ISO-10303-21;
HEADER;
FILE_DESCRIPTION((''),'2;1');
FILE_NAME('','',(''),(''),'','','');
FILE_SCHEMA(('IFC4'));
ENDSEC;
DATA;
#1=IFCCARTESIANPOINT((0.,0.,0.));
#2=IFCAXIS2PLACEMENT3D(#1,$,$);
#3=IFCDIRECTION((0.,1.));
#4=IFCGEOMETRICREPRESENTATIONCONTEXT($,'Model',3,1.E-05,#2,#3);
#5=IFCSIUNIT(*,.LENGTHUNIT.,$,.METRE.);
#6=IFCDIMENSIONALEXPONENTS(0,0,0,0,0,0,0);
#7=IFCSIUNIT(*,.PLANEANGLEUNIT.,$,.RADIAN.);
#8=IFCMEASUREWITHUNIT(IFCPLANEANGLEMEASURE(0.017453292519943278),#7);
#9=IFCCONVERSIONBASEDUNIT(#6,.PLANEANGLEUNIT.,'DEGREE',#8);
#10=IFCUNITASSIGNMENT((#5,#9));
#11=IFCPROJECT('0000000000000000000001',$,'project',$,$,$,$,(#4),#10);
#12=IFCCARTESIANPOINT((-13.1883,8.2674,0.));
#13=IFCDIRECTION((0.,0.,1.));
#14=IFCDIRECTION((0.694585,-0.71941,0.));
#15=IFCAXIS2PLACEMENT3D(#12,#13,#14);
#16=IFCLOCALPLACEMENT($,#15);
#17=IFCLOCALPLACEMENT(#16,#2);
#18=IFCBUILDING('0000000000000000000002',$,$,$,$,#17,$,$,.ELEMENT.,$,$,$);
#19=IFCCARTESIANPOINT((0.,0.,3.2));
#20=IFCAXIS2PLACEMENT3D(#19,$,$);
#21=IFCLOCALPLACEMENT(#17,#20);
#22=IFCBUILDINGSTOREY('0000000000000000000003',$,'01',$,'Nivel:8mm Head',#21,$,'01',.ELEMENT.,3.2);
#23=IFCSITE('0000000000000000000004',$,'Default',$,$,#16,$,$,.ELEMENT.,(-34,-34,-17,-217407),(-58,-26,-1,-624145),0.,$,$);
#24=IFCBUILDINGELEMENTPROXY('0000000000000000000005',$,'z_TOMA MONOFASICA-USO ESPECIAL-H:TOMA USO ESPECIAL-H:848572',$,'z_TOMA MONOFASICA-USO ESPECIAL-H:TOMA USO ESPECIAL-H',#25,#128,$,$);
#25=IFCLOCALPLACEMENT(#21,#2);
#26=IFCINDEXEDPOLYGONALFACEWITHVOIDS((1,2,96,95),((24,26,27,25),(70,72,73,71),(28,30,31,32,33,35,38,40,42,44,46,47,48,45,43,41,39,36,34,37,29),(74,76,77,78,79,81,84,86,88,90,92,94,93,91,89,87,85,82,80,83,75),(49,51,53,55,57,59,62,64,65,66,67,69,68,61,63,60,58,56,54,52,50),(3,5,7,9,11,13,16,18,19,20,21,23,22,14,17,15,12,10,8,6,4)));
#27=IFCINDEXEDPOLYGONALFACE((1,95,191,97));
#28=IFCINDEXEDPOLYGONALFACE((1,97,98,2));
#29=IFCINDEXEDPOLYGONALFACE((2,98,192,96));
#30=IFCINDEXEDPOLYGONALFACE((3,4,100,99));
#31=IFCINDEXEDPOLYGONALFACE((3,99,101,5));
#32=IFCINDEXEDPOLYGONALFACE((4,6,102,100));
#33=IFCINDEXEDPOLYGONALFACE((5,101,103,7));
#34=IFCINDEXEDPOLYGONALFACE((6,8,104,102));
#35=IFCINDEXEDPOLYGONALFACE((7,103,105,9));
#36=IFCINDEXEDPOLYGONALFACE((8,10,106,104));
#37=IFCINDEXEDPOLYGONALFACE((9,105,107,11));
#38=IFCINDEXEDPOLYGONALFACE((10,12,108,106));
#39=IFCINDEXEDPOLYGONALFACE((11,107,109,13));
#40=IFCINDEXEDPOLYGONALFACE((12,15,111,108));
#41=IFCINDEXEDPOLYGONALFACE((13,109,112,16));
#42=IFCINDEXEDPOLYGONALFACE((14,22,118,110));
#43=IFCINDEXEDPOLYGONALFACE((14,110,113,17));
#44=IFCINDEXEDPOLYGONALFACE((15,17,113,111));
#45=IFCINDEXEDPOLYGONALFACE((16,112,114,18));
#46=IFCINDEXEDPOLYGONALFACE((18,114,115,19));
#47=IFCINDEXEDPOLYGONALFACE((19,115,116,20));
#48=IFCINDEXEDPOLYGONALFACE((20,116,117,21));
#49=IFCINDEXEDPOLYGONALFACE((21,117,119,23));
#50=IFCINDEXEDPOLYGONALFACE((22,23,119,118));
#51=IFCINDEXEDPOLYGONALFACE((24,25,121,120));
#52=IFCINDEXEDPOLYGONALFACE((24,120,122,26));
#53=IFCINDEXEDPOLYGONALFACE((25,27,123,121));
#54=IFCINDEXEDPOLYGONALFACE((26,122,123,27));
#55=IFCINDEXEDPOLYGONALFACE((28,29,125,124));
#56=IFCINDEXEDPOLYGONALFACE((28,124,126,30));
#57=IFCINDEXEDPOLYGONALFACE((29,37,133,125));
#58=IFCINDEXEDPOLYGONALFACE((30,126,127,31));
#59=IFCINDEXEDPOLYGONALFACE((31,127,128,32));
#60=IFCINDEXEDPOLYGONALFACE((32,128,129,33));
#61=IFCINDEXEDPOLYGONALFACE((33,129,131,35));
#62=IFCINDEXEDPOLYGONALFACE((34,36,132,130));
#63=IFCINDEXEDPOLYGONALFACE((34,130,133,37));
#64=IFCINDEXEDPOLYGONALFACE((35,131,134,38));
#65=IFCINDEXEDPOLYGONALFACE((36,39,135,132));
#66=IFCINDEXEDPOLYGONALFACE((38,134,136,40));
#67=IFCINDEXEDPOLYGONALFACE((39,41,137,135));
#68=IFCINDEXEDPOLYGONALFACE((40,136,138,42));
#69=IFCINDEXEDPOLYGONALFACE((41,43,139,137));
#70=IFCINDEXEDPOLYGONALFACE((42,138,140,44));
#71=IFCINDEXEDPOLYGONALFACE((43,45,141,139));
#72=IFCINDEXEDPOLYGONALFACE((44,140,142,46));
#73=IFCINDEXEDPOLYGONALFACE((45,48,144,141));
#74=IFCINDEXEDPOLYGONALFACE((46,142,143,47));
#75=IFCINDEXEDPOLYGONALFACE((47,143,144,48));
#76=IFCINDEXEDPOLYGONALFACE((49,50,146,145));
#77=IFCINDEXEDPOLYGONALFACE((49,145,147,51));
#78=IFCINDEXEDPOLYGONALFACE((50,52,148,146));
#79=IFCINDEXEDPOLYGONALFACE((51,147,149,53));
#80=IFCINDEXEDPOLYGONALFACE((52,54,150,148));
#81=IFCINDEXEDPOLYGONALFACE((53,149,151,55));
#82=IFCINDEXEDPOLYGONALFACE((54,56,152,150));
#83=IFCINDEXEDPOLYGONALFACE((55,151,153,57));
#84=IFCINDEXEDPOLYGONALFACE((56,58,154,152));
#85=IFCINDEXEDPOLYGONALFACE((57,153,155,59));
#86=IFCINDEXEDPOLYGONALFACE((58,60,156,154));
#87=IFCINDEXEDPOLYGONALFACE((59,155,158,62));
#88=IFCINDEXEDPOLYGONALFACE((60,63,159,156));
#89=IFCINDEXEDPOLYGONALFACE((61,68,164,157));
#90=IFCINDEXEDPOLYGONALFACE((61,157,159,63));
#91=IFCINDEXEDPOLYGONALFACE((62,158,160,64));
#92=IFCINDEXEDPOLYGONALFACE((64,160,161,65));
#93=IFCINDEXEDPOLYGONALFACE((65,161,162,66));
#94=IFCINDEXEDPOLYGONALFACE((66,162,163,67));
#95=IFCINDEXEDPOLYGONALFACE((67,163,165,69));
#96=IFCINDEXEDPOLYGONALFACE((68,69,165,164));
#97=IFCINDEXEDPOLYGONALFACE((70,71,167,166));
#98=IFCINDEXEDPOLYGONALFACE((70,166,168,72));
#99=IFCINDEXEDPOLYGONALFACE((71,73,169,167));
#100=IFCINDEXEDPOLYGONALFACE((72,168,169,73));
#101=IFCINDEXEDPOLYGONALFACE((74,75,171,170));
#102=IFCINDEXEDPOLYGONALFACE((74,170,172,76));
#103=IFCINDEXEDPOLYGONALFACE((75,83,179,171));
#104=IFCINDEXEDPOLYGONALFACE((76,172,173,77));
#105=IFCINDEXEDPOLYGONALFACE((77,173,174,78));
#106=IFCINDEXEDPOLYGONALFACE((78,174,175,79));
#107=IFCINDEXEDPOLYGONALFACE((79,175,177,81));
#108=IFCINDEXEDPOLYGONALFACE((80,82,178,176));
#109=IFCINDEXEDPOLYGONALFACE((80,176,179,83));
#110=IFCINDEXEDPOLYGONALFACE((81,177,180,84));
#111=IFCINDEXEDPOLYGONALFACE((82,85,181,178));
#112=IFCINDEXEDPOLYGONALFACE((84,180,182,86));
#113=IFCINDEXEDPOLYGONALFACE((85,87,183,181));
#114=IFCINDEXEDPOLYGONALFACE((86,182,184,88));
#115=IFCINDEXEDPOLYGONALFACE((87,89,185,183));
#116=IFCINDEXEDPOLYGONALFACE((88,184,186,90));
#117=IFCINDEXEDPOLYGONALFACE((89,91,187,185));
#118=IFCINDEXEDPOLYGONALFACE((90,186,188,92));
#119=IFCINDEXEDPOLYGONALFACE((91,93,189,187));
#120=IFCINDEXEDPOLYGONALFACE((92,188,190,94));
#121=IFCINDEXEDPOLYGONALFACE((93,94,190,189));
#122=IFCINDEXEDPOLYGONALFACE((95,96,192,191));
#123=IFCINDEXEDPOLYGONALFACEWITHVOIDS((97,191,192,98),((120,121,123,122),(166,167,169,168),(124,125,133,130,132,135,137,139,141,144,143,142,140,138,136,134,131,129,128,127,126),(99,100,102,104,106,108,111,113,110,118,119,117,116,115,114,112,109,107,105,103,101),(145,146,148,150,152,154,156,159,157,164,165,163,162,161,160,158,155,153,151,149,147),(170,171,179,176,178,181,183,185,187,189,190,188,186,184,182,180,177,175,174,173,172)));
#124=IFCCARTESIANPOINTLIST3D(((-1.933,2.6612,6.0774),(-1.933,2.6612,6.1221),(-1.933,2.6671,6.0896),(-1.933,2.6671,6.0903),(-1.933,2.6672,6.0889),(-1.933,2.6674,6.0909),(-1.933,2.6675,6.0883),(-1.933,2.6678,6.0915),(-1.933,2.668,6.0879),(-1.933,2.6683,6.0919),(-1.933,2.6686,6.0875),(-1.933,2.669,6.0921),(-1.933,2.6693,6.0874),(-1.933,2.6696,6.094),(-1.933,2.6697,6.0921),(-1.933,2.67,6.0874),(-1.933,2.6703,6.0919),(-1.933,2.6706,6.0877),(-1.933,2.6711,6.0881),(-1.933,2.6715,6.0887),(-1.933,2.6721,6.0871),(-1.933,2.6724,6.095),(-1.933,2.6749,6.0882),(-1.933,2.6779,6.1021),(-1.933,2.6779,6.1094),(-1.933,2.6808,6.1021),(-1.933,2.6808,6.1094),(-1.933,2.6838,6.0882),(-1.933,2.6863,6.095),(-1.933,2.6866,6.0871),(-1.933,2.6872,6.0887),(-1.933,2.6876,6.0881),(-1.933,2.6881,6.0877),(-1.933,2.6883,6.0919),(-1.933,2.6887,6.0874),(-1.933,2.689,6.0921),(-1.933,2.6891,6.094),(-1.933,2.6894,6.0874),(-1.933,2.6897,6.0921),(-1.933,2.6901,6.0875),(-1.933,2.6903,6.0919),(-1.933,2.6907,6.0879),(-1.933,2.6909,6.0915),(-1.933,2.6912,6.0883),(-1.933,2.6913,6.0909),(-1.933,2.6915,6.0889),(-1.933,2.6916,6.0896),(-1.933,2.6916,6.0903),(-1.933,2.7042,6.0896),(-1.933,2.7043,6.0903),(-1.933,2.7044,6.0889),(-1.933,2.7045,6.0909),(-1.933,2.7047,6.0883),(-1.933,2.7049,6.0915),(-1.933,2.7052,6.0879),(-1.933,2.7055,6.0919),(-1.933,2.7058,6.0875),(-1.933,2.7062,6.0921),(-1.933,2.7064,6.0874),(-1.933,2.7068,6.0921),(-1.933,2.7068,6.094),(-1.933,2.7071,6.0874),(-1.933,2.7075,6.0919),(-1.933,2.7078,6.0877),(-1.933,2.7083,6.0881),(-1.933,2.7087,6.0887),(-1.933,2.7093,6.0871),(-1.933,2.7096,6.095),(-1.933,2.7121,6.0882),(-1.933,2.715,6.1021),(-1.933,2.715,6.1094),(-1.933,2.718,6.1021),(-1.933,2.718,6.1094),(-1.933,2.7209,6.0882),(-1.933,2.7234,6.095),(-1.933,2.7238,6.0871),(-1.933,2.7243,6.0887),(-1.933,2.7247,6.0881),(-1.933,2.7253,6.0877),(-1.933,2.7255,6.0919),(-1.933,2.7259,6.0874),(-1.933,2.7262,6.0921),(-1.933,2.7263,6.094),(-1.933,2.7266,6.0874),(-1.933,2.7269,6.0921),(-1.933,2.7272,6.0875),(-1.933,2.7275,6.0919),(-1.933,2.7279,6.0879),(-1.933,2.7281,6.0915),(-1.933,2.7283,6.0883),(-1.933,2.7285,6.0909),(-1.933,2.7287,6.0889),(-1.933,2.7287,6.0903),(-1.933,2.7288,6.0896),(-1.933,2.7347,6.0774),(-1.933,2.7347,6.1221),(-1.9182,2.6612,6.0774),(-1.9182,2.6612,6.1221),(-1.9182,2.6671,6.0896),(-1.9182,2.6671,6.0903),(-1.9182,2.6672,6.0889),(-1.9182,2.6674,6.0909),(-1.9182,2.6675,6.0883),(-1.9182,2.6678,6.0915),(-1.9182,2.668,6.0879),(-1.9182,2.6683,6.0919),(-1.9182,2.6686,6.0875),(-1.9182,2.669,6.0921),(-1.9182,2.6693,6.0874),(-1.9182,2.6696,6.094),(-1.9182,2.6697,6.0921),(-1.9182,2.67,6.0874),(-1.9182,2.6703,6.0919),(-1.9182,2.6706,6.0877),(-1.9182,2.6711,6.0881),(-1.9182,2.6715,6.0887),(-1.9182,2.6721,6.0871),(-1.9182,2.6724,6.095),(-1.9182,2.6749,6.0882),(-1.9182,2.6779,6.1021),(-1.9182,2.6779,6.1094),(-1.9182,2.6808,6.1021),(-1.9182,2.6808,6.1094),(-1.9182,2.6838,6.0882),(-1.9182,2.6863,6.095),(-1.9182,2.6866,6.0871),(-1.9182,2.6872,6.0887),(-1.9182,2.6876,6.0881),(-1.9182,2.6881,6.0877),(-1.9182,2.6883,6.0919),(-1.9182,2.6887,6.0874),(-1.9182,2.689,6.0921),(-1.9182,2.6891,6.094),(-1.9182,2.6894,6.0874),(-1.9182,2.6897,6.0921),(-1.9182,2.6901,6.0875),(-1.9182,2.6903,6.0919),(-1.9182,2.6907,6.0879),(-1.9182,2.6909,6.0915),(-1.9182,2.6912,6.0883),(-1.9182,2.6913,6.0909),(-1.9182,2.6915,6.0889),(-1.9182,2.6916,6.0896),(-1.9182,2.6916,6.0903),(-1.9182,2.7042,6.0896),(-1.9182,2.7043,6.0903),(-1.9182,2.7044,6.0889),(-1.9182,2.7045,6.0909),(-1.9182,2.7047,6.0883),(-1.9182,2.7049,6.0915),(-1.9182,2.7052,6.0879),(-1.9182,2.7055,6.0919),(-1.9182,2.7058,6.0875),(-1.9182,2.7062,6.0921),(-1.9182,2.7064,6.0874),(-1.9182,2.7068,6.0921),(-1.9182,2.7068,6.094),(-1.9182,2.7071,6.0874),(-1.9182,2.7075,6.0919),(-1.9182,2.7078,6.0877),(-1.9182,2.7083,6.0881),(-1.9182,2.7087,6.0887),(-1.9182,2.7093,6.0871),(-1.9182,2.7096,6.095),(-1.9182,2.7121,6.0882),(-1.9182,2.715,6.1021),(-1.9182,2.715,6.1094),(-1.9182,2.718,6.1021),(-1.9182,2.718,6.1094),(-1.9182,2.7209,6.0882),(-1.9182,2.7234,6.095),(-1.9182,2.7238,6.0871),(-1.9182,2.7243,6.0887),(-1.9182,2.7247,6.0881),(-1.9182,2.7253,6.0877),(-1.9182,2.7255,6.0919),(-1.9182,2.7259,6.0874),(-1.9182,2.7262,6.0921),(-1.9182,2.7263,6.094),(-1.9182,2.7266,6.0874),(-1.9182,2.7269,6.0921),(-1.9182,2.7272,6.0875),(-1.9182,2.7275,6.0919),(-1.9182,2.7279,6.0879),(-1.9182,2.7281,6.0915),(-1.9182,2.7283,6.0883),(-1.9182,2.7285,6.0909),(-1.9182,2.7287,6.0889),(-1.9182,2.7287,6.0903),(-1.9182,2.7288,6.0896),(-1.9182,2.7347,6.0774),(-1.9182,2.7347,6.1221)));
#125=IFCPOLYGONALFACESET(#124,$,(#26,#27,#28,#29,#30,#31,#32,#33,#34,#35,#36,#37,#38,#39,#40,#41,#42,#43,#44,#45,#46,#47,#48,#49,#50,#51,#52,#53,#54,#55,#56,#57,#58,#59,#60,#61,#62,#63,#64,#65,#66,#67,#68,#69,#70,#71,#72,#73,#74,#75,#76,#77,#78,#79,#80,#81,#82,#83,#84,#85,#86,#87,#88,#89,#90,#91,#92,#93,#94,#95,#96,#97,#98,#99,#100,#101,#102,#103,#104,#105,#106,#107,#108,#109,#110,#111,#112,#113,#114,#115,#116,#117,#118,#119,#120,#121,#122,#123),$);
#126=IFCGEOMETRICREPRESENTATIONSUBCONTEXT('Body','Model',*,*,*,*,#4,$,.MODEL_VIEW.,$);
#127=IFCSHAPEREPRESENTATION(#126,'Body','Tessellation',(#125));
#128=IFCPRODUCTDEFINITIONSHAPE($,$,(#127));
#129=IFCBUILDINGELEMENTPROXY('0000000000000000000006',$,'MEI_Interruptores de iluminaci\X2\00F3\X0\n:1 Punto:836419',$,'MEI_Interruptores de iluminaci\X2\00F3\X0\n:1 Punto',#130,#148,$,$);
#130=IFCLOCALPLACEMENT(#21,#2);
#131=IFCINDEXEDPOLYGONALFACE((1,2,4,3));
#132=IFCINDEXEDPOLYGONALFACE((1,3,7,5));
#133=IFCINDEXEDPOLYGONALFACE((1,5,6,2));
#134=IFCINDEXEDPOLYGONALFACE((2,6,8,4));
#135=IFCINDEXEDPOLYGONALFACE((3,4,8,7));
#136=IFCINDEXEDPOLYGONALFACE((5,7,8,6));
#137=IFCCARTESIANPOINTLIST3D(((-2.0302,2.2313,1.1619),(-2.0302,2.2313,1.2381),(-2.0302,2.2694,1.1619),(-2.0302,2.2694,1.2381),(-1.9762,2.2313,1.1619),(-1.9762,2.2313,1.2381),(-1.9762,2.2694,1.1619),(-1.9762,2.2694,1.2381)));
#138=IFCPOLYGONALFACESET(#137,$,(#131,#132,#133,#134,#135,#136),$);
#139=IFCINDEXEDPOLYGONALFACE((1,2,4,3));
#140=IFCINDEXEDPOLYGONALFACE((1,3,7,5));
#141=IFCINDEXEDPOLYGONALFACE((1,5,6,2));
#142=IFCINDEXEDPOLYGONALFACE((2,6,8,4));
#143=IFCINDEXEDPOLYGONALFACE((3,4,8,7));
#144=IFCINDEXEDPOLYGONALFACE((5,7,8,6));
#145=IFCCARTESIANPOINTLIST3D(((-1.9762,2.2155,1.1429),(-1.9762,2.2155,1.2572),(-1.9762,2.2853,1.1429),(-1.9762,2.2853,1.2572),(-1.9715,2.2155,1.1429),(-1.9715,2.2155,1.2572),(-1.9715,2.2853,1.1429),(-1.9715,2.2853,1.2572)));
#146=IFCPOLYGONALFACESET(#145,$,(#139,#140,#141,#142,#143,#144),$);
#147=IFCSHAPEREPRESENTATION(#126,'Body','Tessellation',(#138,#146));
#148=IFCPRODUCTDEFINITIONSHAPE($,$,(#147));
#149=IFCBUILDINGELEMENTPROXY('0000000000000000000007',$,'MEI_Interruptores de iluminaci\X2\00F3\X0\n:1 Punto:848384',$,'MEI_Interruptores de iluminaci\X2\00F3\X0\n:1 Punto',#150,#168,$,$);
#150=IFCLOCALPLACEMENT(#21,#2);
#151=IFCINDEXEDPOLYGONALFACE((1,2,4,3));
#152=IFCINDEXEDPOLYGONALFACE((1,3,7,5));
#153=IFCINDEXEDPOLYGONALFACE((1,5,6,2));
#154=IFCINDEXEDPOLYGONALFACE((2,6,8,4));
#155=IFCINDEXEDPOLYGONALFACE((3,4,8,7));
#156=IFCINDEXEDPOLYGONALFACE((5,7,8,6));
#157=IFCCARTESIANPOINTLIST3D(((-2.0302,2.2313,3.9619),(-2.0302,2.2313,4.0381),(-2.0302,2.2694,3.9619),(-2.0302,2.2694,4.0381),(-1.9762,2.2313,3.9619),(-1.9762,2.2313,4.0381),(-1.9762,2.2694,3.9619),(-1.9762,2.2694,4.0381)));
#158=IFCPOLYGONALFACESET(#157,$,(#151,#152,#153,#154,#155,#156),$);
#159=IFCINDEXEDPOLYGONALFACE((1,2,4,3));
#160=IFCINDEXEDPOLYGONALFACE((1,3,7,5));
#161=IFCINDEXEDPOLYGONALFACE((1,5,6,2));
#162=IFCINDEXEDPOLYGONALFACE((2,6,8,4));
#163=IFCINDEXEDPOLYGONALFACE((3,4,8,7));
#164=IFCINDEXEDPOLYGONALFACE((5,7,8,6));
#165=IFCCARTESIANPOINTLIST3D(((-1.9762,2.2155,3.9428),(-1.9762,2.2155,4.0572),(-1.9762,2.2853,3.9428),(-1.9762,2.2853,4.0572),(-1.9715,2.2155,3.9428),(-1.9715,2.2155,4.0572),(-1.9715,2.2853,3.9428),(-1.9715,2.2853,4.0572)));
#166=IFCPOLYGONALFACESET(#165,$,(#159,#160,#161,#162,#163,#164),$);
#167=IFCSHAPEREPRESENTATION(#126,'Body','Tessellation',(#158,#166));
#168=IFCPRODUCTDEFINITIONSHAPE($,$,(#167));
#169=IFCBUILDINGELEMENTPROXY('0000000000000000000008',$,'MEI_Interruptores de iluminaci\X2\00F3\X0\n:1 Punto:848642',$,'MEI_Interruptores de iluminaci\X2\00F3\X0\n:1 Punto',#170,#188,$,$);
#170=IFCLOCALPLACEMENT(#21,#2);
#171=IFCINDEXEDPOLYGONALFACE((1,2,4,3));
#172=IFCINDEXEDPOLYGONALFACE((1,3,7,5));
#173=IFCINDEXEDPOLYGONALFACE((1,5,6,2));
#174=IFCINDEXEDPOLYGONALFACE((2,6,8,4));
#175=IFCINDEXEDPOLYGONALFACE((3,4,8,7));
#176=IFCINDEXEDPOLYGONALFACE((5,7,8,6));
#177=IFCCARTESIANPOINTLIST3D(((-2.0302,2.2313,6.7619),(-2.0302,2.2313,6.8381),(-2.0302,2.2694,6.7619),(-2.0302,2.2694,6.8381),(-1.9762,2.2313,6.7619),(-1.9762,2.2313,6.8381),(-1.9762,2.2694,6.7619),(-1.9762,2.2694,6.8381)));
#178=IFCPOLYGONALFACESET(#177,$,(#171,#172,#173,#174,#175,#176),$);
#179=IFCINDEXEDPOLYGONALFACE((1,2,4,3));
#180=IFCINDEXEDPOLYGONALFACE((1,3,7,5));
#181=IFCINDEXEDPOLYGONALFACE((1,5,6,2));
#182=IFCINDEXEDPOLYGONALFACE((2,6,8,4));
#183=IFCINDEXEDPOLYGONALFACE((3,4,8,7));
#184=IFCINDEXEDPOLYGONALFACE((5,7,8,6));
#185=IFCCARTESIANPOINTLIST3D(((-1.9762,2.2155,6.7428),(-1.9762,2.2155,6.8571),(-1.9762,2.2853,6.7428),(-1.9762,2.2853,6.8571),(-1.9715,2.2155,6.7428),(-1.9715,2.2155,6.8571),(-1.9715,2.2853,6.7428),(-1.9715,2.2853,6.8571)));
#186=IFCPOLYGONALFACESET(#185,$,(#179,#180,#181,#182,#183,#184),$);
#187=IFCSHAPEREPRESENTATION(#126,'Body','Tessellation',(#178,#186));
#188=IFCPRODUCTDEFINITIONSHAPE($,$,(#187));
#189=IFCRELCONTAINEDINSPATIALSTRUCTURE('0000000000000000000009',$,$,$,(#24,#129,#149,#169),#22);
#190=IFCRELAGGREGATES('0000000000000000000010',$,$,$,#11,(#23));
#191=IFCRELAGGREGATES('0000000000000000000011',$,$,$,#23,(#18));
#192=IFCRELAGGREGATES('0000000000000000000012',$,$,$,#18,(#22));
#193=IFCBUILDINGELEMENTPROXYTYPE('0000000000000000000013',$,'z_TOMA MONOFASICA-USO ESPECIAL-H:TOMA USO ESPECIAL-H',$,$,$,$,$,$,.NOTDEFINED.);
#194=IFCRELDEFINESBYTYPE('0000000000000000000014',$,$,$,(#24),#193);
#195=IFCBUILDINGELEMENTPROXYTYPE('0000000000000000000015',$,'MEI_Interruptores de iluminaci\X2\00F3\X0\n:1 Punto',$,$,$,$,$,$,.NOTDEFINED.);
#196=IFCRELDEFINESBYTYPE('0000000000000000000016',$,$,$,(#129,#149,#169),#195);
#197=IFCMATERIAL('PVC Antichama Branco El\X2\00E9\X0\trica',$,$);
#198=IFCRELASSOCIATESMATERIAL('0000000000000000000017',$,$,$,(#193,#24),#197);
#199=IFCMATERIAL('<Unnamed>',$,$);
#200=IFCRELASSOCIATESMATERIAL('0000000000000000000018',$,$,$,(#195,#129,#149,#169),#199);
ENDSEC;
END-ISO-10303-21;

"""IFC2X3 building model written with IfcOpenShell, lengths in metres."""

from ifc_helpers import new_model, entity, si_unit, converted_unit, direction, frame, frame_2d, origin, origin_2d_with_axis, place, context, subcontext, project, spatial, polyline, circle_curve, parameter, trimmed, segment, composite_curve, rectangle, outline, extrude, source, transform, mapped, material, type_object, type_shapes, element, save


model = new_model("IFC2X3")

# Units and contexts
model_context = context("Model", 3, precision=1e-05, world=origin(), true_north=direction((0.0, 1.0)))
body_context = subcontext(model_context, "Body", "Model", "MODEL_VIEW")
ifc_project = project(units=[si_unit("LENGTHUNIT", "METRE"), converted_unit("PLANEANGLEUNIT", "DEGREE", entity("IfcPlaneAngleMeasure", 0.017453292519943278), si_unit("PLANEANGLEUNIT", "RADIAN"), dimensions=[0, 0, 0, 0, 0, 0, 0])], contexts=[model_context])

# Site, building, storey
site_placement = place(None, frame((-13.1883, 8.2674, 0.0), z_axis=(0.0, 0.0, 1.0), x_axis=(0.694585, -0.71941, 0.0)))
site = spatial("IfcSite", under=ifc_project, at=site_placement, Name="Default", CompositionType="ELEMENT", RefLatitude=(-34, -34, -17, -217407), RefLongitude=(-58, -26, -1, -624145), RefElevation=0.0)
building_placement = place(site_placement, origin())
building = spatial("IfcBuilding", under=site, at=building_placement, CompositionType="ELEMENT")
storey_placement = place(building_placement, frame((0.0, 0.0, 3.2)))
storey = spatial("IfcBuildingStorey", under=building, at=storey_placement, Name="01", ObjectType="Nivel:8mm Head", LongName="01", CompositionType="ELEMENT", Elevation=3.2)

# Building element proxies
ifc_material_1 = material(Name="PVC Antichama Branco Elétrica")
building_element_proxy_type_1 = type_object("IfcBuildingElementProxyType", Name="z_TOMA MONOFASICA-USO ESPECIAL-H:TOMA USO ESPECIAL-H", PredefinedType="NOTDEFINED", material=ifc_material_1)
shared_shape_1 = source(origin(), body_context, "Body", "SweptSolid", [
    extrude(outline(polyline([(-0.0368, -0.0223), (0.0368, -0.0223), (0.0368, 0.0223), (-0.0368, 0.0223), (-0.0368, -0.0223)]), holes=[composite_curve([segment(polyline([(0.0141, 0.0115), (0.0116, 0.0047)]), True, "CONTINUOUS"), segment(polyline([(0.0116, 0.0047), (0.0088, 0.0057)]), True, "CONTINUOUS"), segment(polyline([(0.0088, 0.0057), (0.0096, 0.0078)]), True, "CONTINUOUS"), segment(trimmed(circle_curve(frame_2d((0.0087, 0.0099), x_axis=(1.0, 0.0)), 0.0024), [parameter(27.118901)], [parameter(292.881099)], True, "PARAMETER"), False, "CONTINUOUS"), segment(polyline([(0.0108, 0.011), (0.0113, 0.0126)]), True, "CONTINUOUS"), segment(polyline([(0.0113, 0.0126), (0.0141, 0.0115)]), True, "CONTINUOUS")], self_intersect=False), composite_curve([segment(polyline([(0.0255, 0.0047), (0.023, 0.0115)]), True, "CONTINUOUS"), segment(polyline([(0.023, 0.0115), (0.0258, 0.0126)]), True, "CONTINUOUS"), segment(polyline([(0.0258, 0.0126), (0.0264, 0.011)]), True, "CONTINUOUS"), segment(trimmed(circle_curve(frame_2d((0.0285, 0.0099), x_axis=(1.0, 0.0)), 0.0024), [parameter(247.118901)], [parameter(152.881099)], True, "PARAMETER"), False, "CONTINUOUS"), segment(polyline([(0.0276, 0.0078), (0.0283, 0.0057)]), True, "CONTINUOUS"), segment(polyline([(0.0283, 0.0057), (0.0255, 0.0047)]), True, "CONTINUOUS")], self_intersect=False), polyline([(0.0201, -0.0024), (0.0201, -0.0097), (0.0171, -0.0097), (0.0171, -0.0024), (0.0201, -0.0024)]), composite_curve([segment(polyline([(-0.0141, 0.0115), (-0.0113, 0.0126)]), True, "CONTINUOUS"), segment(polyline([(-0.0113, 0.0126), (-0.0108, 0.011)]), True, "CONTINUOUS"), segment(trimmed(circle_curve(frame_2d((-0.0087, 0.0099), x_axis=(1.0, 0.0)), 0.0024), [parameter(247.118901)], [parameter(152.881099)], True, "PARAMETER"), False, "CONTINUOUS"), segment(polyline([(-0.0096, 0.0078), (-0.0088, 0.0057)]), True, "CONTINUOUS"), segment(polyline([(-0.0088, 0.0057), (-0.0116, 0.0047)]), True, "CONTINUOUS"), segment(polyline([(-0.0116, 0.0047), (-0.0141, 0.0115)]), True, "CONTINUOUS")], self_intersect=False), composite_curve([segment(polyline([(-0.0255, 0.0047), (-0.0283, 0.0057)]), True, "CONTINUOUS"), segment(polyline([(-0.0283, 0.0057), (-0.0276, 0.0078)]), True, "CONTINUOUS"), segment(trimmed(circle_curve(frame_2d((-0.0285, 0.0099), x_axis=(1.0, 0.0)), 0.0024), [parameter(27.118901)], [parameter(292.881099)], True, "PARAMETER"), False, "CONTINUOUS"), segment(polyline([(-0.0264, 0.011), (-0.0258, 0.0126)]), True, "CONTINUOUS"), segment(polyline([(-0.0258, 0.0126), (-0.023, 0.0115)]), True, "CONTINUOUS"), segment(polyline([(-0.023, 0.0115), (-0.0255, 0.0047)]), True, "CONTINUOUS")], self_intersect=False), polyline([(-0.0201, -0.0024), (-0.0171, -0.0024), (-0.0171, -0.0097), (-0.0201, -0.0097), (-0.0201, -0.0024)])]), frame((0.0, -0.005, 0.0223), z_axis=(0.0, 1.0, 0.0), x_axis=(1.0, 0.0, 0.0)), (0.0, 0.0, 1.0), 0.0148),
])
type_shapes(building_element_proxy_type_1, [shared_shape_1])
for number, where, z_axis, x_axis, name in (
    (1, (-1.928, 2.6979, 6.0774), (0.0, 0.0, 1.0), (0.0, -1.0, 0.0), "z_TOMA MONOFASICA-USO ESPECIAL-H:TOMA USO ESPECIAL-H:848572"),
):
    element("IfcBuildingElementProxy", number, at=place(storey_placement, frame(where, z_axis=z_axis, x_axis=x_axis)), inside=storey, type_object=building_element_proxy_type_1, material=ifc_material_1, Name=name, ObjectType="z_TOMA MONOFASICA-USO ESPECIAL-H:TOMA USO ESPECIAL-H", context=body_context, shape_type="MappedRepresentation", body=[
        mapped(shared_shape_1, transform((0.0, 0.0, 0.0), scale=1.0)),
    ])
ifc_material_2 = material(Name="<Unnamed>")
building_element_proxy_type_2 = type_object("IfcBuildingElementProxyType", Name="MEI_Interruptores de iluminación:1 Punto", PredefinedType="NOTDEFINED", material=ifc_material_2)
shared_shape_2 = source(origin(), body_context, "Body", "SweptSolid", [
    extrude(rectangle(XDim=0.0381, YDim=0.0762, at=origin_2d_with_axis()), frame((0.0, 0.0, -0.054), z_axis=(0.0, 0.0, 1.0), x_axis=(-1.0, 0.0, 0.0)), (0.0, 0.0, 1.0), 0.054),
    extrude(rectangle(XDim=0.0698, YDim=0.1143, at=frame_2d((0.0, 0.0), x_axis=(1.0, 0.0))), frame((0.0, 0.0, 0.0), z_axis=(0.0, 0.0, 1.0), x_axis=(-1.0, 0.0, 0.0)), (0.0, 0.0, 1.0), 0.0048),
])
type_shapes(building_element_proxy_type_2, [shared_shape_2])
for number, where, z_axis, x_axis, name in (
    (2, (-1.9762, 2.2504, 1.2), (1.0, 0.0, 0.0), (0.0, 1.0, 0.0), "MEI_Interruptores de iluminación:1 Punto:836419"),
    (3, (-1.9762, 2.2504, 4.0), (1.0, 0.0, 0.0), (0.0, 1.0, 0.0), "MEI_Interruptores de iluminación:1 Punto:848384"),
    (4, (-1.9762, 2.2504, 6.8), (1.0, 0.0, 0.0), (0.0, 1.0, 0.0), "MEI_Interruptores de iluminación:1 Punto:848642"),
):
    element("IfcBuildingElementProxy", number, at=place(storey_placement, frame(where, z_axis=z_axis, x_axis=x_axis)), inside=storey, type_object=building_element_proxy_type_2, material=ifc_material_2, Name=name, ObjectType="MEI_Interruptores de iluminación:1 Punto", context=body_context, shape_type="MappedRepresentation", body=[
        mapped(shared_shape_2, transform((0.0, 0.0, 0.0), scale=1.0)),
    ])

save(model, "model.ifc")
